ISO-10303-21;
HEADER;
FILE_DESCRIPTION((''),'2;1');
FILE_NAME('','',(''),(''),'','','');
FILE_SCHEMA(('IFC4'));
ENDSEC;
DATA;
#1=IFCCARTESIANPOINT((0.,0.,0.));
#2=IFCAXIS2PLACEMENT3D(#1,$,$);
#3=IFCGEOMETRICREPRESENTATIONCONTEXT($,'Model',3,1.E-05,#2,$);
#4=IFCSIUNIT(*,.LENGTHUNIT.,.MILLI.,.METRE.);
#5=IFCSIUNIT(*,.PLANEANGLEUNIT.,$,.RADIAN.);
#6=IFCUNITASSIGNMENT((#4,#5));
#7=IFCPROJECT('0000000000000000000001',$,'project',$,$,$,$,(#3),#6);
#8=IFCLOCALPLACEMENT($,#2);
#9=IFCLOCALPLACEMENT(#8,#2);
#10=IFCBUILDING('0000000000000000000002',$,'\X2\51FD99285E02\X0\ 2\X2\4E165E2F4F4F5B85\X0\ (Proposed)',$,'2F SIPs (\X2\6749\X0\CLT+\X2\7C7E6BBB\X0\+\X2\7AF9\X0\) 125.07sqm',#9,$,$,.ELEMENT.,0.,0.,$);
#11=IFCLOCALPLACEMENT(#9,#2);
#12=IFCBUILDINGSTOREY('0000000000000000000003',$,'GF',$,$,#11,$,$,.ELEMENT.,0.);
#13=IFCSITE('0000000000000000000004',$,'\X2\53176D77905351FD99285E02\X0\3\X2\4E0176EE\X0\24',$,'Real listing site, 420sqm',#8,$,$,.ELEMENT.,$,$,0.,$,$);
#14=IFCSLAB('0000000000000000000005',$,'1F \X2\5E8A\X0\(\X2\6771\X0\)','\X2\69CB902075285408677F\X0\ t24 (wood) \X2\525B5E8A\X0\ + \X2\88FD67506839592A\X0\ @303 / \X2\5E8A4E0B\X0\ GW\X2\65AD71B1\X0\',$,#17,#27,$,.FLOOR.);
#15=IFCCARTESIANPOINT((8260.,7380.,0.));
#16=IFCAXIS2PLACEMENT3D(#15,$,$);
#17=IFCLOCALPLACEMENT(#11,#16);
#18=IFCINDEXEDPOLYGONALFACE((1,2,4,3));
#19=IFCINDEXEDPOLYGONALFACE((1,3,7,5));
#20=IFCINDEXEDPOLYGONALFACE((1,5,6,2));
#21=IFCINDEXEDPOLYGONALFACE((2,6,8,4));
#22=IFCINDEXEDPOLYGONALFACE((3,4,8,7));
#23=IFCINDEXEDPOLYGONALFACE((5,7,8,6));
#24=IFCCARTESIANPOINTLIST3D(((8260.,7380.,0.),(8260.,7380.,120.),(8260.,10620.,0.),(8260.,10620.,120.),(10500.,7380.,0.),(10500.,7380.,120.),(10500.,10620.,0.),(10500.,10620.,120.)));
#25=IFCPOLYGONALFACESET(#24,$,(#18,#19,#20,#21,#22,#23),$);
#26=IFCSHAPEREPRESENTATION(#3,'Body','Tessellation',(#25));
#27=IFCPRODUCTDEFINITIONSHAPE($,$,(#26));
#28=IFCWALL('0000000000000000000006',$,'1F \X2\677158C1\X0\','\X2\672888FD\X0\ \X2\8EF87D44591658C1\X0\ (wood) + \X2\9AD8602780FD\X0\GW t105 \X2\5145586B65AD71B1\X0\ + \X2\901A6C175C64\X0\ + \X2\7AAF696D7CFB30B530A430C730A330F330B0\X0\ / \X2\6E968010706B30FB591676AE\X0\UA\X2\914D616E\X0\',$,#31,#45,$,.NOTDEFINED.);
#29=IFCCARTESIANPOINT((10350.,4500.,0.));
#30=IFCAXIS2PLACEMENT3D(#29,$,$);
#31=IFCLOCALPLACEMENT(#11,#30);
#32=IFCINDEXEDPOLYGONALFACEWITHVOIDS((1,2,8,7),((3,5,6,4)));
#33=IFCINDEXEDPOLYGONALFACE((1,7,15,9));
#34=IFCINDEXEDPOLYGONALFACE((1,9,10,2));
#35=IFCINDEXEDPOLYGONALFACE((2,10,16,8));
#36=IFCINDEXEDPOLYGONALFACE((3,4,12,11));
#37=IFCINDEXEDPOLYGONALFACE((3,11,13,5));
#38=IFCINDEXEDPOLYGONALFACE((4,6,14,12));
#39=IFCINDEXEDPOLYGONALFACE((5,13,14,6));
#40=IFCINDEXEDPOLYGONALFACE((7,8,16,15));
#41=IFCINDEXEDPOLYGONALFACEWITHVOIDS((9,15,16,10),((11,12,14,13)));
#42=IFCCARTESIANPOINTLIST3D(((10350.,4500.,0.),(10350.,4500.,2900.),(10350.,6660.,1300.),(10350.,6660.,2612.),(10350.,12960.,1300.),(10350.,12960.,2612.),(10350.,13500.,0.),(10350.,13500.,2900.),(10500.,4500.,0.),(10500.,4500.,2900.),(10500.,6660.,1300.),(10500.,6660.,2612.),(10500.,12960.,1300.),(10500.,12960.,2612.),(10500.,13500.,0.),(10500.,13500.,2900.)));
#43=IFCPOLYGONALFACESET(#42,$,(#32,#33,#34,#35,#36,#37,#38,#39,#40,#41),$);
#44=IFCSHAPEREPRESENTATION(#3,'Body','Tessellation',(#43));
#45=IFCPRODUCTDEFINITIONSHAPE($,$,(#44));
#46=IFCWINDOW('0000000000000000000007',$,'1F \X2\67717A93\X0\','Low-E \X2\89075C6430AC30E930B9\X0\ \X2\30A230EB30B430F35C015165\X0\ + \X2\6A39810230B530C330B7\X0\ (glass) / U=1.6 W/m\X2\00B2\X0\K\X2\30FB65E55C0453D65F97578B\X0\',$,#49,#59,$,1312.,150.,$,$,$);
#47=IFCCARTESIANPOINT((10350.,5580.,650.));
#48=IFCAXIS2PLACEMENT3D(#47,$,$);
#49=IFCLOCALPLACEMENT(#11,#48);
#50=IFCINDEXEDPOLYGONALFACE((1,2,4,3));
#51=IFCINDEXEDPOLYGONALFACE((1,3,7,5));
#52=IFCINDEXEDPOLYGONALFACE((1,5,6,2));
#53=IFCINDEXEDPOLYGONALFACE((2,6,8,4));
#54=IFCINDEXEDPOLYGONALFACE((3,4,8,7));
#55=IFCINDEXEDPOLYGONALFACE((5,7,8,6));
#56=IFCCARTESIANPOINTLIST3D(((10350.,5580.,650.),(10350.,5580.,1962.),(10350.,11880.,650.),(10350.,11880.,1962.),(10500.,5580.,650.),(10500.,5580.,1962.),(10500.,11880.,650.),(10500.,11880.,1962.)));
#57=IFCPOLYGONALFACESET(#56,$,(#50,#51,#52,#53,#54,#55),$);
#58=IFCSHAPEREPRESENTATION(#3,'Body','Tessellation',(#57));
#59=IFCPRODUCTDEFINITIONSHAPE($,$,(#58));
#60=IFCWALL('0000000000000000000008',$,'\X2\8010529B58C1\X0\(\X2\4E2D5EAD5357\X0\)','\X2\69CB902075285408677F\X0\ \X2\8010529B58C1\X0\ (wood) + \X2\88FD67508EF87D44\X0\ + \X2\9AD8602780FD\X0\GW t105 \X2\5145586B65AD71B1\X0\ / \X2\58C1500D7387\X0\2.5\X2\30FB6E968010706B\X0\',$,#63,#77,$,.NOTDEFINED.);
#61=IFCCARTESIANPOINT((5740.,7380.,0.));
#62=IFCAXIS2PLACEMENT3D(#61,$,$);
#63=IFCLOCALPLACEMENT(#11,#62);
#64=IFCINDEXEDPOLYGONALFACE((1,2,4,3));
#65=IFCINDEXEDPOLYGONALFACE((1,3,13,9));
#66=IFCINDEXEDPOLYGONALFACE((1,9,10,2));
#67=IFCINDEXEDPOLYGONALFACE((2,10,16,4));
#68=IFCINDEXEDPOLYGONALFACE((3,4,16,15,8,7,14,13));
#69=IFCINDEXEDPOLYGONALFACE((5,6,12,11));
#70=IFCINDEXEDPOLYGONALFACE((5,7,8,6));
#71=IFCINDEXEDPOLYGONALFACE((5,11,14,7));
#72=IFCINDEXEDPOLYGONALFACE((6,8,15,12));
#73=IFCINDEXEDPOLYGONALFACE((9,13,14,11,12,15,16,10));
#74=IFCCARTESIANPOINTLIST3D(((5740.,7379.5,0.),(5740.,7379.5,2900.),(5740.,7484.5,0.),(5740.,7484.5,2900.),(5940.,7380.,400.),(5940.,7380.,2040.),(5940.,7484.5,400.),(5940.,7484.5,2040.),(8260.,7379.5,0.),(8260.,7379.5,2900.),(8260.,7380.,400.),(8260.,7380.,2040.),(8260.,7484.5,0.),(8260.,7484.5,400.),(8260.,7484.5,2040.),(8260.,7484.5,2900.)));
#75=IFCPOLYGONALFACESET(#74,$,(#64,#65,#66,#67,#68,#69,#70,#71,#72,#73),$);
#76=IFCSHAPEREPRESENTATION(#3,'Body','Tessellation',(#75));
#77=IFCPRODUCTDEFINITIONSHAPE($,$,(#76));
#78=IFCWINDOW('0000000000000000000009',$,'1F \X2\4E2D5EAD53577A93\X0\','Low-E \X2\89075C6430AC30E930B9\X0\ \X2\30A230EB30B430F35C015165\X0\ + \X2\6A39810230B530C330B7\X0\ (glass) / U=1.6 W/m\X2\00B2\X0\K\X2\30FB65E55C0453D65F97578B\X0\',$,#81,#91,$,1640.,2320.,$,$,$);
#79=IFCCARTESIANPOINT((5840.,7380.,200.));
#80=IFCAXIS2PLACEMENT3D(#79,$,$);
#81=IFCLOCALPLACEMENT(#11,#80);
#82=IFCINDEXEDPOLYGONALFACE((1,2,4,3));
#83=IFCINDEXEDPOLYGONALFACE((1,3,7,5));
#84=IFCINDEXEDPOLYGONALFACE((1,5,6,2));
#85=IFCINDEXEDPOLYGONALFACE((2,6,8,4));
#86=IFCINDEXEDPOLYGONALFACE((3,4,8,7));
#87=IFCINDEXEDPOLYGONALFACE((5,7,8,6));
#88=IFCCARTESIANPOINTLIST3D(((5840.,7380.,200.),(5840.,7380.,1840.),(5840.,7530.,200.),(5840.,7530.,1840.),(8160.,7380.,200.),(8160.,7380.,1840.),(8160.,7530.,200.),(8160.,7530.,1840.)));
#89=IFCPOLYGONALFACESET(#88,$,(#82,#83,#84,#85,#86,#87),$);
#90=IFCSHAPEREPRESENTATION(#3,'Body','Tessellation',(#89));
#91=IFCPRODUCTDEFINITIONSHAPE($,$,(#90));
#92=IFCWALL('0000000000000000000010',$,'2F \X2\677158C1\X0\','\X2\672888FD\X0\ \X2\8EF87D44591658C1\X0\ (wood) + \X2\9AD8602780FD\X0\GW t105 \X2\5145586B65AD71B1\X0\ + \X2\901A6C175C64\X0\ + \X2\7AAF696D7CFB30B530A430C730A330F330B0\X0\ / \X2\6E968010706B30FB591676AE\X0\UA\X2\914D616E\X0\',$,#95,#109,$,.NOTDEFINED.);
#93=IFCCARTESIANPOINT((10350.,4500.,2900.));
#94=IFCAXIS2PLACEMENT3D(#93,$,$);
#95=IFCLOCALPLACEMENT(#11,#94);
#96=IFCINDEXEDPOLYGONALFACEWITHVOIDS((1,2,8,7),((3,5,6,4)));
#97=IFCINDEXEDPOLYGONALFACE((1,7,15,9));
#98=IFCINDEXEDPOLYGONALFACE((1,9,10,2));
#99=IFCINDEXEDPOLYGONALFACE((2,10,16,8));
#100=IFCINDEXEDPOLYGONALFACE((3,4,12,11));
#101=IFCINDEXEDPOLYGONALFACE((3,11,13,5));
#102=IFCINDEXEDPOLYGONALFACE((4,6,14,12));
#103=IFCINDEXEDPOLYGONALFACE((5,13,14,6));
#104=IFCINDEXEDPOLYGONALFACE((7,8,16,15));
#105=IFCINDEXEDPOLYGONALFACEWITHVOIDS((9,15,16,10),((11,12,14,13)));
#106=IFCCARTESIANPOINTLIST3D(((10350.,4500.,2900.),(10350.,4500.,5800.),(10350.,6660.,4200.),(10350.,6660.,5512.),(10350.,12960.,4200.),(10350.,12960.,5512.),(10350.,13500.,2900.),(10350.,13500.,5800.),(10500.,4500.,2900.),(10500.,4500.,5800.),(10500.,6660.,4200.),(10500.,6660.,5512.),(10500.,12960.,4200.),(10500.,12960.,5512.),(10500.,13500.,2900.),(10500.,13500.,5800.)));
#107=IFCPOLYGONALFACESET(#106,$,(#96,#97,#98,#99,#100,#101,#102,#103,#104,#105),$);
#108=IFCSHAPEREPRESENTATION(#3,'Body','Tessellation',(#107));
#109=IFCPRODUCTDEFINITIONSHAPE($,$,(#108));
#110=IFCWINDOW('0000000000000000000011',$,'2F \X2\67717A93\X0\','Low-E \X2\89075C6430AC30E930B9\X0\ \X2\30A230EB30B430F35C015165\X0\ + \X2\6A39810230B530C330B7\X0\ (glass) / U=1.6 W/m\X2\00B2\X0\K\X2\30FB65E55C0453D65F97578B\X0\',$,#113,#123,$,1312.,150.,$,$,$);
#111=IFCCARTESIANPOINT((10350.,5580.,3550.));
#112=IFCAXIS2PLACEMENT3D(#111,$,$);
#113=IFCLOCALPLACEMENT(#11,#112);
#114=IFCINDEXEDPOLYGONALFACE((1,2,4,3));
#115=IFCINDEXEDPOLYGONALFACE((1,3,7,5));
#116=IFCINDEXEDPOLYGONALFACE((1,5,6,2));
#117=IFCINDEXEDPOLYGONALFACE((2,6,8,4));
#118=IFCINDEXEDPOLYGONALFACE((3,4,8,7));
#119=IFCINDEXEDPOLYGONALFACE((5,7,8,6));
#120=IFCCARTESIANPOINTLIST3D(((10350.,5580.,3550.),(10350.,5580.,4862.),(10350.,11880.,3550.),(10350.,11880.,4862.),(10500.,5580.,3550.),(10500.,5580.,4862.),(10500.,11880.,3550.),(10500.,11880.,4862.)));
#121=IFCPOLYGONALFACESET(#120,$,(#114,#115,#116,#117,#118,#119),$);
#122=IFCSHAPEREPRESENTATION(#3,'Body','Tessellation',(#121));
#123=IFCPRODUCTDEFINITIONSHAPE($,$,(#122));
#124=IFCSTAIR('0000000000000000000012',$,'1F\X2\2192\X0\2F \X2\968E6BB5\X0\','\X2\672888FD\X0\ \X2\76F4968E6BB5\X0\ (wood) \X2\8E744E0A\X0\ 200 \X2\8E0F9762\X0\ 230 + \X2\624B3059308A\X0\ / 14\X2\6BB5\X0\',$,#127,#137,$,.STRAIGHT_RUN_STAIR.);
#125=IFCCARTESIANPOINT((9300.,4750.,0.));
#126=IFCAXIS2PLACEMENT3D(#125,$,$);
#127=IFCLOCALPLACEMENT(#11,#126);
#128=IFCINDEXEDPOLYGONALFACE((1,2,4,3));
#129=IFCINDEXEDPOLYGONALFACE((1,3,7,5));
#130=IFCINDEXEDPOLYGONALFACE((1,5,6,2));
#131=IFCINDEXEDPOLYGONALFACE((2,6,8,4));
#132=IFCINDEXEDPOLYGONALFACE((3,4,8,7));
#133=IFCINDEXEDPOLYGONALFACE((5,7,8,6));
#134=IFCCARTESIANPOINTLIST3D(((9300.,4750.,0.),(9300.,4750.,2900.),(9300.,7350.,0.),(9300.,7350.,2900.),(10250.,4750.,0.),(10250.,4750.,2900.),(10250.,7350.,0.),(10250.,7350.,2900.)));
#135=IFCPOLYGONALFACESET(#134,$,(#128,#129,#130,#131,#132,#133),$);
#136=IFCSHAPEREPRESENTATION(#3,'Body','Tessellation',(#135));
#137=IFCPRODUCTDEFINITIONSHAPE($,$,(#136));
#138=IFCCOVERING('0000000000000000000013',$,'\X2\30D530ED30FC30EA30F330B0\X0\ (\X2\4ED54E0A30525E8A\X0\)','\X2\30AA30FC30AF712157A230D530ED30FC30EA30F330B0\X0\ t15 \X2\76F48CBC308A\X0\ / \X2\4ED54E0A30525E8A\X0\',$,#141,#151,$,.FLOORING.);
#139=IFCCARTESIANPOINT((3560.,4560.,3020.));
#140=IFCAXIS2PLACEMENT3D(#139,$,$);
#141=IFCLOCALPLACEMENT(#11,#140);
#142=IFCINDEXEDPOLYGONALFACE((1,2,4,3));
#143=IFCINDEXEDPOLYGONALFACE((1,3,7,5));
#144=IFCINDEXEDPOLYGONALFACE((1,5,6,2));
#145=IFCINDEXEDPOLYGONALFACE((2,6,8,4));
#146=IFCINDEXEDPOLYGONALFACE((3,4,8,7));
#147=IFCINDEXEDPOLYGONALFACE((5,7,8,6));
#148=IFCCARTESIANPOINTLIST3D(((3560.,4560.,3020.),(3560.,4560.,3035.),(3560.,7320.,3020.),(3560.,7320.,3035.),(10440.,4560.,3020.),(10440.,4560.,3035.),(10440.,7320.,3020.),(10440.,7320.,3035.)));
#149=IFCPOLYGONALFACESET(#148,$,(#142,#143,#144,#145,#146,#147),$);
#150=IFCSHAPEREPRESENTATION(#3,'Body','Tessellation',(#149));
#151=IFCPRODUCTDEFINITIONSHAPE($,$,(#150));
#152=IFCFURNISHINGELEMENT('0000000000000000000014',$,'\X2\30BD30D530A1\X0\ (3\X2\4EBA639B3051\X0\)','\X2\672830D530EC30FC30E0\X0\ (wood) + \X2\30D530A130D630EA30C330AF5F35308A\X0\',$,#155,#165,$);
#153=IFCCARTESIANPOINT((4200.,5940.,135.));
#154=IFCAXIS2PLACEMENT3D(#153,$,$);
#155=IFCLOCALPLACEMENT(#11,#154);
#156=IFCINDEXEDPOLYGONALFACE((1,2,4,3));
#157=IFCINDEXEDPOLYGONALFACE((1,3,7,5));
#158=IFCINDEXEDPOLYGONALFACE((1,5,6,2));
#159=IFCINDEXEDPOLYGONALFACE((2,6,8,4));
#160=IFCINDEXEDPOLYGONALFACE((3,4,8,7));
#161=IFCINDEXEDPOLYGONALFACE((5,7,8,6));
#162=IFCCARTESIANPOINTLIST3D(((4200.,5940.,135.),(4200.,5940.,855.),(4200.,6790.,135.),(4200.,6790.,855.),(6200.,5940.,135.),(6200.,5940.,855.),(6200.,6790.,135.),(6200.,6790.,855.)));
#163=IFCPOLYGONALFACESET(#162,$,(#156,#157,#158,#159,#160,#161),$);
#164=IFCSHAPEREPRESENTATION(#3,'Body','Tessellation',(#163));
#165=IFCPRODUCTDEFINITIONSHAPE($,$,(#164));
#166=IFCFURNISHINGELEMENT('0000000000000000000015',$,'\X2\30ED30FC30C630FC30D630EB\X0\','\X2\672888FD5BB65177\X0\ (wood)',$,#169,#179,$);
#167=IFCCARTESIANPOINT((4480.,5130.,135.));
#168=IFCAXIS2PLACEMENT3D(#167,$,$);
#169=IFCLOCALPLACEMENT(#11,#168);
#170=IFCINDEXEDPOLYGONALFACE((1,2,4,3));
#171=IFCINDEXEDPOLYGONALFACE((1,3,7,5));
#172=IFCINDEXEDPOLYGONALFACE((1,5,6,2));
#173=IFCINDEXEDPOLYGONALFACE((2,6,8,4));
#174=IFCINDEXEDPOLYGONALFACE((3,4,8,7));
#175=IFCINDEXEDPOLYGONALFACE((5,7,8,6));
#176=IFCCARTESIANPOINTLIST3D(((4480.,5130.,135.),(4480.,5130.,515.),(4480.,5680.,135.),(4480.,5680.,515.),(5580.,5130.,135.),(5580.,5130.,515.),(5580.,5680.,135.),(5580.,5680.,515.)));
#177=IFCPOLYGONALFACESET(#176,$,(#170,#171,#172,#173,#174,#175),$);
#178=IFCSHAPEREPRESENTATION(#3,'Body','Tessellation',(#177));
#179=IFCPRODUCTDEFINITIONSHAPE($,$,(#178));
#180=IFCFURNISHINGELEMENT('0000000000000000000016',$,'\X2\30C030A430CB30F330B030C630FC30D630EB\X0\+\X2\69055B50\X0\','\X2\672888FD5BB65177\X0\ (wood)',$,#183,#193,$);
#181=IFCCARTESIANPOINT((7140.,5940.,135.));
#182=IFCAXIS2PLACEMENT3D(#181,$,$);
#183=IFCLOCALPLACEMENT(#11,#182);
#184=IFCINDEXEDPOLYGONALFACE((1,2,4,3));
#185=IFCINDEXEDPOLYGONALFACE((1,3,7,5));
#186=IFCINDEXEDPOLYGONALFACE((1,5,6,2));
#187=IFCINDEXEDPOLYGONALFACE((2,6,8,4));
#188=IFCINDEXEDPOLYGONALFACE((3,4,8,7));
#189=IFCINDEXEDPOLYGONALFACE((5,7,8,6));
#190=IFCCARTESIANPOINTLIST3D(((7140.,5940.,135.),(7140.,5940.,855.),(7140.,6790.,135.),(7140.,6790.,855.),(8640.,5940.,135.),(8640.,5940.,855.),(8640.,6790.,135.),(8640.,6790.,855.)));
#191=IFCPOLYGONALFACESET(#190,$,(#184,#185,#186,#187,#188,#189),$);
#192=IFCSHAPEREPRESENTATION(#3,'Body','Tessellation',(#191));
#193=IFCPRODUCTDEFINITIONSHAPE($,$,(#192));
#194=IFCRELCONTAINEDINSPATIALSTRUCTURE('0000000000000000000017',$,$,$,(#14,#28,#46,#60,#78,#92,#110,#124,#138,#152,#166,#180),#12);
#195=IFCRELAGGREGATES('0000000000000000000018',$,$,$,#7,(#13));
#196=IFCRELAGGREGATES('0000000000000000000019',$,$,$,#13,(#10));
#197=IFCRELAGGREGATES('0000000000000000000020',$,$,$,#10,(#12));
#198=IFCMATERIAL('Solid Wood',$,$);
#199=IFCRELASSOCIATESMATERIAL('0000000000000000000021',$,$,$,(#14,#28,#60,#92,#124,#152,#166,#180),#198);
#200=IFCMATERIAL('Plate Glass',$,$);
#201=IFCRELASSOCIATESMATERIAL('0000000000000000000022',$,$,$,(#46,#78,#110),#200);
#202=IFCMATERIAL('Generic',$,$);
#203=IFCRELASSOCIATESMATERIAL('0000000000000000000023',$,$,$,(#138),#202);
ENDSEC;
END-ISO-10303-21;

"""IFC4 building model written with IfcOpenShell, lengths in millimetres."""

from ifc_helpers import new_model, si_unit, frame, frame_2d, origin, place, context, project, spatial, rectangle, extrude, material, element, fill, save


model = new_model("IFC4")

# Units and contexts
model_context = context("Model", 3, precision=1e-05, world=origin())
ifc_project = project(units=[si_unit("LENGTHUNIT", "METRE", prefix="MILLI"), si_unit("PLANEANGLEUNIT", "RADIAN")], contexts=[model_context])

# Site, building, storey
site_placement = place(None, origin())
site = spatial("IfcSite", under=ifc_project, at=site_placement, Name="北海道函館市3丁目24", ObjectType="Real listing site, 420sqm", CompositionType="ELEMENT", RefElevation=0.0)
building_placement = place(site_placement, origin())
building = spatial("IfcBuilding", under=site, at=building_placement, Name="函館市 2世帯住宅 (Proposed)", ObjectType="2F SIPs (杉CLT+籾殻+竹) 125.07sqm", CompositionType="ELEMENT", ElevationOfRefHeight=0.0, ElevationOfTerrain=0.0)
storey_placement = place(building_placement, origin())
storey = spatial("IfcBuildingStorey", under=building, at=storey_placement, Name="GF", CompositionType="ELEMENT", Elevation=0.0)

# Slab
ifc_material_1 = material(Name="Solid Wood")
slab_placement = place(storey_placement, frame((8260.0, 7380.0, 0.0)))
element("IfcSlab", 1, at=slab_placement, inside=storey, material=ifc_material_1, Name="1F 床(東)", Description="構造用合板 t24 (wood) 剛床 + 製材根太 @303 / 床下 GW断熱", PredefinedType="FLOOR", context=model_context, shape_type="SweptSolid", body=[
    extrude(rectangle(XDim=2240.0, YDim=3240.0, at=frame_2d((1120.0, 1620.0))), frame((8260.0, 7380.0, 0.0)), (0.0, 0.0, 1.0), 120.0),
])

# Walls, openings, windows
wall_1_placement = place(storey_placement, frame((10350.0, 4500.0, 0.0)))
wall_1 = element("IfcWall", 2, at=wall_1_placement, inside=storey, material=ifc_material_1, Name="1F 東壁", Description="木製 軸組外壁 (wood) + 高性能GW t105 充填断熱 + 通気層 + 窯業系サイディング / 準耐火・外皮UA配慮", PredefinedType="NOTDEFINED", context=model_context, shape_type="SweptSolid", body=[
    extrude(rectangle(XDim=150.0, YDim=9000.0, at=frame_2d((75.0, 4500.0))), frame((10350.0, 4500.0, 0.0)), (0.0, 0.0, 1.0), 2900.0),
])
opening_1_placement = place(storey_placement, frame((10350.0, 5580.0, 650.0)))
opening_1 = element("IfcOpeningElement", 3, at=opening_1_placement, cuts=wall_1, PredefinedType="NOTDEFINED", context=model_context, shape_type="SweptSolid", body=[
    extrude(rectangle(XDim=150.0, YDim=6300.0, at=frame_2d((75.0, 3150.0))), frame((10350.0, 5580.0, 650.0)), (0.0, 0.0, 1.0), 1312.0),
])
ifc_material_2 = material(Name="Plate Glass")
window_1_placement = place(storey_placement, frame((10350.0, 5580.0, 650.0)))
window_1 = element("IfcWindow", 4, at=window_1_placement, inside=storey, material=ifc_material_2, Name="1F 東窓", Description="Low-E 複層ガラス アルゴン封入 + 樹脂サッシ (glass) / U=1.6 W/m²K・日射取得型", OverallHeight=1312.0, OverallWidth=150.0, context=model_context, shape_type="SweptSolid", body=[
    extrude(rectangle(XDim=150.0, YDim=6300.0, at=frame_2d((75.0, 3150.0))), frame((10350.0, 5580.0, 650.0)), (0.0, 0.0, 1.0), 1312.0),
])
fill(opening_1, window_1)
wall_2_placement = place(storey_placement, frame((5740.0, 7380.0, 0.0)))
wall_2 = element("IfcWall", 5, at=wall_2_placement, inside=storey, material=ifc_material_1, Name="耐力壁(中庭南)", Description="構造用合板 耐力壁 (wood) + 製材軸組 + 高性能GW t105 充填断熱 / 壁倍率2.5・準耐火", PredefinedType="NOTDEFINED", context=model_context, shape_type="SweptSolid", body=[
    extrude(rectangle(XDim=2520.0, YDim=105.0, at=frame_2d((1260.0, 52.0))), frame((5740.0, 7380.0, 0.0)), (0.0, 0.0, 1.0), 2900.0),
])
opening_2_placement = place(storey_placement, frame((5840.0, 7380.0, 200.0)))
opening_2 = element("IfcOpeningElement", 6, at=opening_2_placement, cuts=wall_2, PredefinedType="NOTDEFINED", context=model_context, shape_type="SweptSolid", body=[
    extrude(rectangle(XDim=2320.0, YDim=150.0, at=frame_2d((1160.0, 75.0))), frame((5840.0, 7380.0, 200.0)), (0.0, 0.0, 1.0), 1640.0),
])
window_2_placement = place(storey_placement, frame((5840.0, 7380.0, 200.0)))
window_2 = element("IfcWindow", 7, at=window_2_placement, inside=storey, material=ifc_material_2, Name="1F 中庭南窓", Description="Low-E 複層ガラス アルゴン封入 + 樹脂サッシ (glass) / U=1.6 W/m²K・日射取得型", OverallHeight=1640.0, OverallWidth=2320.0, context=model_context, shape_type="SweptSolid", body=[
    extrude(rectangle(XDim=2320.0, YDim=150.0, at=frame_2d((1160.0, 75.0))), frame((5840.0, 7380.0, 200.0)), (0.0, 0.0, 1.0), 1640.0),
])
fill(opening_2, window_2)

# Wall, opening, window
wall_3_placement = place(storey_placement, frame((10350.0, 4500.0, 2900.0)))
wall_3 = element("IfcWall", 8, at=wall_3_placement, inside=storey, material=ifc_material_1, Name="2F 東壁", Description="木製 軸組外壁 (wood) + 高性能GW t105 充填断熱 + 通気層 + 窯業系サイディング / 準耐火・外皮UA配慮", PredefinedType="NOTDEFINED", context=model_context, shape_type="SweptSolid", body=[
    extrude(rectangle(XDim=150.0, YDim=9000.0, at=frame_2d((75.0, 4500.0))), frame((10350.0, 4500.0, 2900.0)), (0.0, 0.0, 1.0), 2900.0),
])
opening_3_placement = place(storey_placement, frame((10350.0, 5580.0, 3550.0)))
opening_3 = element("IfcOpeningElement", 9, at=opening_3_placement, cuts=wall_3, PredefinedType="NOTDEFINED", context=model_context, shape_type="SweptSolid", body=[
    extrude(rectangle(XDim=150.0, YDim=6300.0, at=frame_2d((75.0, 3150.0))), frame((10350.0, 5580.0, 3550.0)), (0.0, 0.0, 1.0), 1312.0),
])
window_3_placement = place(storey_placement, frame((10350.0, 5580.0, 3550.0)))
window_3 = element("IfcWindow", 10, at=window_3_placement, inside=storey, material=ifc_material_2, Name="2F 東窓", Description="Low-E 複層ガラス アルゴン封入 + 樹脂サッシ (glass) / U=1.6 W/m²K・日射取得型", OverallHeight=1312.0, OverallWidth=150.0, context=model_context, shape_type="SweptSolid", body=[
    extrude(rectangle(XDim=150.0, YDim=6300.0, at=frame_2d((75.0, 3150.0))), frame((10350.0, 5580.0, 3550.0)), (0.0, 0.0, 1.0), 1312.0),
])
fill(opening_3, window_3)

# Stair
stair_placement = place(storey_placement, frame((9300.0, 4750.0, 0.0)))
element("IfcStair", 11, at=stair_placement, inside=storey, material=ifc_material_1, Name="1F→2F 階段", Description="木製 直階段 (wood) 蹴上 200 踏面 230 + 手すり / 14段", PredefinedType="STRAIGHT_RUN_STAIR", context=model_context, shape_type="SweptSolid", body=[
    extrude(rectangle(XDim=950.0, YDim=2600.0, at=frame_2d((475.0, 1300.0))), frame((9300.0, 4750.0, 0.0)), (0.0, 0.0, 1.0), 2900.0),
])

# Covering
ifc_material_3 = material(Name="Generic")
covering_placement = place(storey_placement, frame((3560.0, 4560.0, 3020.0)))
element("IfcCovering", 12, at=covering_placement, inside=storey, material=ifc_material_3, Name="フローリング (仕上げ床)", Description="オーク無垢フローリング t15 直貼り / 仕上げ床", PredefinedType="FLOORING", context=model_context, shape_type="SweptSolid", body=[
    extrude(rectangle(XDim=6880.0, YDim=2760.0, at=frame_2d((3440.0, 1380.0))), frame((3560.0, 4560.0, 3020.0)), (0.0, 0.0, 1.0), 15.0),
])

# Furnishing elements
furnishing_1_placement = place(storey_placement, frame((4200.0, 5940.0, 135.0)))
element("IfcFurnishingElement", 13, at=furnishing_1_placement, inside=storey, material=ifc_material_1, Name="ソファ (3人掛け)", Description="木フレーム (wood) + ファブリック張り", context=model_context, shape_type="SweptSolid", body=[
    extrude(rectangle(XDim=2000.0, YDim=850.0, at=frame_2d((1000.0, 425.0))), frame((4200.0, 5940.0, 135.0)), (0.0, 0.0, 1.0), 720.0),
])
furnishing_2_placement = place(storey_placement, frame((4480.0, 5130.0, 135.0)))
element("IfcFurnishingElement", 14, at=furnishing_2_placement, inside=storey, material=ifc_material_1, Name="ローテーブル", Description="木製家具 (wood)", context=model_context, shape_type="SweptSolid", body=[
    extrude(rectangle(XDim=1100.0, YDim=550.0, at=frame_2d((550.0, 275.0))), frame((4480.0, 5130.0, 135.0)), (0.0, 0.0, 1.0), 380.0),
])
furnishing_3_placement = place(storey_placement, frame((7140.0, 5940.0, 135.0)))
element("IfcFurnishingElement", 15, at=furnishing_3_placement, inside=storey, material=ifc_material_1, Name="ダイニングテーブル+椅子", Description="木製家具 (wood)", context=model_context, shape_type="SweptSolid", body=[
    extrude(rectangle(XDim=1500.0, YDim=850.0, at=frame_2d((750.0, 425.0))), frame((7140.0, 5940.0, 135.0)), (0.0, 0.0, 1.0), 720.0),
])

save(model, "model.ifc")
